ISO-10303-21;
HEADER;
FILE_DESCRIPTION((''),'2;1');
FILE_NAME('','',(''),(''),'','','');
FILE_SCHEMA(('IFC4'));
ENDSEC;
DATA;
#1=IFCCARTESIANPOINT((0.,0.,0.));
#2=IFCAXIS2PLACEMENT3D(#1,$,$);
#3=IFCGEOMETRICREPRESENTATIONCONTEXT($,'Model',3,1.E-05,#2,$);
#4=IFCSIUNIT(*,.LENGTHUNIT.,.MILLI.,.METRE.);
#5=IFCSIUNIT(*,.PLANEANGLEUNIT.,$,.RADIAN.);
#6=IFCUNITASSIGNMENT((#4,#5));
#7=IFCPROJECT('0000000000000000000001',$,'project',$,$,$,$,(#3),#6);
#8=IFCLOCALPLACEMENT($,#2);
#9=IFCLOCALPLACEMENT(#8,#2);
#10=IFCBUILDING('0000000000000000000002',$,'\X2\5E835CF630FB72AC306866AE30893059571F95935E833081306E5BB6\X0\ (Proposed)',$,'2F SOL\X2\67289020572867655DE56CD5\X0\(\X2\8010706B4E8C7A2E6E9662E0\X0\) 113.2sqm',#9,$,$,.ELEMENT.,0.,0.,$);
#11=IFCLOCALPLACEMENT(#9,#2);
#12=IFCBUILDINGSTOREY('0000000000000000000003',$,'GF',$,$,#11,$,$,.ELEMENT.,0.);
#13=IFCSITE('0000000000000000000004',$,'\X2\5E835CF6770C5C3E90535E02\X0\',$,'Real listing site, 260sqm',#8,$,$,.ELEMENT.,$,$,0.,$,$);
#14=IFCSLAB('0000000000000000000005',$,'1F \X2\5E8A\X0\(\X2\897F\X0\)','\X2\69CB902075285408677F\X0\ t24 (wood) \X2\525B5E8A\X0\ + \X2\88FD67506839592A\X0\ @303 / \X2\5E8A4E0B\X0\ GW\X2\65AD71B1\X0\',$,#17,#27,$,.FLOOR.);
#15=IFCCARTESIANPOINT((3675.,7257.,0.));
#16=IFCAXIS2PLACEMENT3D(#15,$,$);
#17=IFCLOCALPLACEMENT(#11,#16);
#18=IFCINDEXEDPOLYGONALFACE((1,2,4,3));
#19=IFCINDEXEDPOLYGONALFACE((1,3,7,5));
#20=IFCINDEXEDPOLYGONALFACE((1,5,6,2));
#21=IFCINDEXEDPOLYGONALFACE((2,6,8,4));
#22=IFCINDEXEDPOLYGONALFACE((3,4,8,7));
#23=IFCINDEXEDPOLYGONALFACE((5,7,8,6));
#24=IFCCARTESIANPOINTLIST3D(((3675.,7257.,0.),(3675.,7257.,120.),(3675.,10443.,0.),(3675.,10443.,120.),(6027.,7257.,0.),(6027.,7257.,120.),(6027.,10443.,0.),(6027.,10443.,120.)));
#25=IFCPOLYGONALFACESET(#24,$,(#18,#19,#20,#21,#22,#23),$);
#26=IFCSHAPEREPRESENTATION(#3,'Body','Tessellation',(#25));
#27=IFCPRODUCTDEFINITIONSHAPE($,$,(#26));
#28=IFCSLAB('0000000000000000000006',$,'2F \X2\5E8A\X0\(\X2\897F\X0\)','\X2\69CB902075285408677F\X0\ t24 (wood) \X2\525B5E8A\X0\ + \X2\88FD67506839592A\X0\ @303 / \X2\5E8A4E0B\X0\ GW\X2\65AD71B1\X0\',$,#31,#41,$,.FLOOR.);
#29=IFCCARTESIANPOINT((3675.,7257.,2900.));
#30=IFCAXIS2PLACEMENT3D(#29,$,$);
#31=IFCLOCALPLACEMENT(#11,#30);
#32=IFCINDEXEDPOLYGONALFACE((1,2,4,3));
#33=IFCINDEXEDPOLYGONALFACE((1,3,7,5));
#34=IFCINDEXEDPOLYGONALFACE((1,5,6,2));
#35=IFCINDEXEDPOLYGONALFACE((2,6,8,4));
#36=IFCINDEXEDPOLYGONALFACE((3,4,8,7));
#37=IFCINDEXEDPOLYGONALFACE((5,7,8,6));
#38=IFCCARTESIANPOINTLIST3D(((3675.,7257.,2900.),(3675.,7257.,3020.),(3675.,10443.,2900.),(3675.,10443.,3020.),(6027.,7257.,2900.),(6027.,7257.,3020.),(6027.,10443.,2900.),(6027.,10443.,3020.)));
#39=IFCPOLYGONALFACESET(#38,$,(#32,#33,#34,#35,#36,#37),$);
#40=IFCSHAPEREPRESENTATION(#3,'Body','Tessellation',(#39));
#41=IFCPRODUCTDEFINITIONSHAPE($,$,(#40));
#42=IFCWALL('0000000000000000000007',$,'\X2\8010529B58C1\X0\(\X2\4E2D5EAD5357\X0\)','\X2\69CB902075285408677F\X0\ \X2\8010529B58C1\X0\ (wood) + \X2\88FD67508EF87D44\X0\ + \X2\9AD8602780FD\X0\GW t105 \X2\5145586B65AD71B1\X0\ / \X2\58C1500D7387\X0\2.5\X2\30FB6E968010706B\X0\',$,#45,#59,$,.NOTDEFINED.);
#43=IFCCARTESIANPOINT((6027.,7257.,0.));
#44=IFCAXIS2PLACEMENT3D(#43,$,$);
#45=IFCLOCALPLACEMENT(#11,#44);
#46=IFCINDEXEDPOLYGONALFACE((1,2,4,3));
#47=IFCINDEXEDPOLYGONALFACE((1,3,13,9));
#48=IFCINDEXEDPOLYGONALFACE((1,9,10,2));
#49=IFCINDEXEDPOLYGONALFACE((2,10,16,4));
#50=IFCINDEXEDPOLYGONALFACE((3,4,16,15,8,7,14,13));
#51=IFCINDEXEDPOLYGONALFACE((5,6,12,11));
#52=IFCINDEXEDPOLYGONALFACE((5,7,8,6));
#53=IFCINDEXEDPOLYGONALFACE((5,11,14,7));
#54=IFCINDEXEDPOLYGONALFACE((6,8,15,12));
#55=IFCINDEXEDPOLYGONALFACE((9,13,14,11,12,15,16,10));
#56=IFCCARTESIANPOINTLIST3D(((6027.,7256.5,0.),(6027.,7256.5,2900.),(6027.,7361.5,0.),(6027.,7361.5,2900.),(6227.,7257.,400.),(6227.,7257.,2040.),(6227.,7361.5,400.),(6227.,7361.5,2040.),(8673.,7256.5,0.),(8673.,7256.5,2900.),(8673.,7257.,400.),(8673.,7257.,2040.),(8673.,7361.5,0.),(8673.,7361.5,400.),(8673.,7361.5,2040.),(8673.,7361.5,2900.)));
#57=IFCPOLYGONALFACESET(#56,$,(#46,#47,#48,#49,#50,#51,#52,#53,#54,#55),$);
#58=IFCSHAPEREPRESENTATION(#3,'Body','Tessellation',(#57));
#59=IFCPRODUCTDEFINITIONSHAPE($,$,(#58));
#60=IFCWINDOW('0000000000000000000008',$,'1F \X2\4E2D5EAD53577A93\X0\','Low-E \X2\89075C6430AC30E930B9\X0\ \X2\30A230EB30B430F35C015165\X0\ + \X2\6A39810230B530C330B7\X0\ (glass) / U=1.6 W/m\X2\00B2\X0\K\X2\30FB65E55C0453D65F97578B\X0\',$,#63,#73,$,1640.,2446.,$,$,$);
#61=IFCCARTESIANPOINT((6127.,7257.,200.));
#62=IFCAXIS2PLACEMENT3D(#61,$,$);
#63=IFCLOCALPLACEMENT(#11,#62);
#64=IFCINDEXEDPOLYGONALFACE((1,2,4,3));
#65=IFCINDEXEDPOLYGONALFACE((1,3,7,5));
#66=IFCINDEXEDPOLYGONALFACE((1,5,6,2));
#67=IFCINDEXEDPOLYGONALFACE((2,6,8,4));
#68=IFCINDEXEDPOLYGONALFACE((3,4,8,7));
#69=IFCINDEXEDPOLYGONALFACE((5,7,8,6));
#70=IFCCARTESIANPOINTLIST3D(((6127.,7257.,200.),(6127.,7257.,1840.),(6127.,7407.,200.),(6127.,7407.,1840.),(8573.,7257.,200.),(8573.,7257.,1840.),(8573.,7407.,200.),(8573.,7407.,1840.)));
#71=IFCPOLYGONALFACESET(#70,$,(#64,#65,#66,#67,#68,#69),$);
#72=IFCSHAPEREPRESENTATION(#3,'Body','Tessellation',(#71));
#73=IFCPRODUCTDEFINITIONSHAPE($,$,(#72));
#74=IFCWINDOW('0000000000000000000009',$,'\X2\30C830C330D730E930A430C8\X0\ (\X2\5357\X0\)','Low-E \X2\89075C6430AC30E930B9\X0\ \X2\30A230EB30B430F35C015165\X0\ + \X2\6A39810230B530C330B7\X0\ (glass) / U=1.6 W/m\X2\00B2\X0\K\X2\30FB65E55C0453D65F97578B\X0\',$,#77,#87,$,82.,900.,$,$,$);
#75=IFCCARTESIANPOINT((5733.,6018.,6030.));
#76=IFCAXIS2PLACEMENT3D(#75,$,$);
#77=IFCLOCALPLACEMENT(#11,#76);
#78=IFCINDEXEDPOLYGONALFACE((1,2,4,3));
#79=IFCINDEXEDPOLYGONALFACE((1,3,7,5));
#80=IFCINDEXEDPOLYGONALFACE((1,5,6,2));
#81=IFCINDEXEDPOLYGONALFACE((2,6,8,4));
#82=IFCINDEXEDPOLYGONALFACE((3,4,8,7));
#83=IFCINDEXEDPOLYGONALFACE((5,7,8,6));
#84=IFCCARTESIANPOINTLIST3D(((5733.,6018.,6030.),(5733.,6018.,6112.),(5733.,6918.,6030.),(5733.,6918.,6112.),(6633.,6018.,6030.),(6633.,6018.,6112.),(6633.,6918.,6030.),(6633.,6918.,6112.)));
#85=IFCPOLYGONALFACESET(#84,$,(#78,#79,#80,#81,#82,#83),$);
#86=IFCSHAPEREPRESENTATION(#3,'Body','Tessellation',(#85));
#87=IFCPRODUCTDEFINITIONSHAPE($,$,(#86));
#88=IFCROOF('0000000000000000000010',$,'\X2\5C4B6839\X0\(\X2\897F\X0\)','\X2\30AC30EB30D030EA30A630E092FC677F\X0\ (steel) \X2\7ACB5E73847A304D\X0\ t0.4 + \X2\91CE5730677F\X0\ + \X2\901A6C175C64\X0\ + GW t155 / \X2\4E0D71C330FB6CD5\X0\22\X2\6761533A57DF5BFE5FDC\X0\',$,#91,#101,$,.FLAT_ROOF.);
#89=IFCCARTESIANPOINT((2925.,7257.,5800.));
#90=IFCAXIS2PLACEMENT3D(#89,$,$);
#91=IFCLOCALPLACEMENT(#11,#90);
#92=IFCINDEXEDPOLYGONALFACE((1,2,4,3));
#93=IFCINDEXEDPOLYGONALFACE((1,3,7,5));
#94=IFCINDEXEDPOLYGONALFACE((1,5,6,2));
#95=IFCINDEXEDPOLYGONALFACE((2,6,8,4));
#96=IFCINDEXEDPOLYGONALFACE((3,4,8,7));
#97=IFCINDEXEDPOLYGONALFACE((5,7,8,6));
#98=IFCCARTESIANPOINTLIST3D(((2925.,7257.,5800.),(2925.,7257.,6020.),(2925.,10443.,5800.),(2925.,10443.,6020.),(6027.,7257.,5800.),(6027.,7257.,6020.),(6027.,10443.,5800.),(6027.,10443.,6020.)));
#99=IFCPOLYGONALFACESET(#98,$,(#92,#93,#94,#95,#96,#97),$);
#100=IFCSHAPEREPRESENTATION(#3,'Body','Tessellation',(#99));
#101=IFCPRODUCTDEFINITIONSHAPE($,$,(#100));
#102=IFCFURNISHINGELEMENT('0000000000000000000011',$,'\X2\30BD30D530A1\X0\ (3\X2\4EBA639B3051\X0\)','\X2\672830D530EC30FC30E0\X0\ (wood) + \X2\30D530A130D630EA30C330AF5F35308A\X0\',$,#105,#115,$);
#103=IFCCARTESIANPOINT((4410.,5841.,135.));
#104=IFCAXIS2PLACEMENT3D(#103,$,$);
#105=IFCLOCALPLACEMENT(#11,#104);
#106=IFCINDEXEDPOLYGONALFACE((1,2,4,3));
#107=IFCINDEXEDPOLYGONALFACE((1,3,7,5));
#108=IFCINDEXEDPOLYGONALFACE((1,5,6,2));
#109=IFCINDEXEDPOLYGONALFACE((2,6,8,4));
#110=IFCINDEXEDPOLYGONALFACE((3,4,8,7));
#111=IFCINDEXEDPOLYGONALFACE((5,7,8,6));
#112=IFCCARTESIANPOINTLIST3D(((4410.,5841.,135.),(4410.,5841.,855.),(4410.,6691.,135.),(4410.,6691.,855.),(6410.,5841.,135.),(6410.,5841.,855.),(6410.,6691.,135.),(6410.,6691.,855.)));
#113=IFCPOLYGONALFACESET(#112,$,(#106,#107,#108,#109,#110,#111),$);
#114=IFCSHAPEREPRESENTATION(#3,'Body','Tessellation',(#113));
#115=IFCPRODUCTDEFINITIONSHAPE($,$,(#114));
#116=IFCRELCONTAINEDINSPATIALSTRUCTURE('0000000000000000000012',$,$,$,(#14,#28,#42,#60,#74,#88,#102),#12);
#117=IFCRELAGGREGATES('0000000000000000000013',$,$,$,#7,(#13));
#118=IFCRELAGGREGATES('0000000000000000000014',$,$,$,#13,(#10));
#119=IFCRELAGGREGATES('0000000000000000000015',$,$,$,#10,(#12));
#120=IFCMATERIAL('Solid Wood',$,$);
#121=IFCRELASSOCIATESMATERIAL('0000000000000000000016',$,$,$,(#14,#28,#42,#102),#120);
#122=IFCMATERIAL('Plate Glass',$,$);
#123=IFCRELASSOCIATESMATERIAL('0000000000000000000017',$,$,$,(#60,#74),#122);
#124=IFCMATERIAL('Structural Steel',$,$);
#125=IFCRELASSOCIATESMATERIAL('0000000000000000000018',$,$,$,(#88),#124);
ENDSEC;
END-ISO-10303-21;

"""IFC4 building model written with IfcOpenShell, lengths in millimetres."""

from ifc_helpers import new_model, si_unit, frame, frame_2d, origin, place, context, project, spatial, rectangle, extrude, material, element, fill, save


model = new_model("IFC4")

# Units and contexts
model_context = context("Model", 3, precision=1e-05, world=origin())
ifc_project = project(units=[si_unit("LENGTHUNIT", "METRE", prefix="MILLI"), si_unit("PLANEANGLEUNIT", "RADIAN")], contexts=[model_context])

# Site, building, storey
site_placement = place(None, origin())
site = spatial("IfcSite", under=ifc_project, at=site_placement, Name="広島県尾道市", ObjectType="Real listing site, 260sqm", CompositionType="ELEMENT", RefElevation=0.0)
building_placement = place(site_placement, origin())
building = spatial("IfcBuilding", under=site, at=building_placement, Name="広島・犬と暮らす土間広めの家 (Proposed)", ObjectType="2F SOL木造在来工法(耐火二種準拠) 113.2sqm", CompositionType="ELEMENT", ElevationOfRefHeight=0.0, ElevationOfTerrain=0.0)
storey_placement = place(building_placement, origin())
storey = spatial("IfcBuildingStorey", under=building, at=storey_placement, Name="GF", CompositionType="ELEMENT", Elevation=0.0)

# Shared definitions
ifc_material_1 = material(Name="Solid Wood")

# Slabs
slab_1_placement = place(storey_placement, frame((3675.0, 7257.0, 0.0)))
element("IfcSlab", 1, at=slab_1_placement, inside=storey, material=ifc_material_1, Name="1F 床(西)", Description="構造用合板 t24 (wood) 剛床 + 製材根太 @303 / 床下 GW断熱", PredefinedType="FLOOR", context=model_context, shape_type="SweptSolid", body=[
    extrude(rectangle(XDim=2352.0, YDim=3186.0, at=frame_2d((1176.0, 1593.0))), frame((3675.0, 7257.0, 0.0)), (0.0, 0.0, 1.0), 120.0),
])
slab_2_placement = place(storey_placement, frame((3675.0, 7257.0, 2900.0)))
element("IfcSlab", 2, at=slab_2_placement, inside=storey, material=ifc_material_1, Name="2F 床(西)", Description="構造用合板 t24 (wood) 剛床 + 製材根太 @303 / 床下 GW断熱", PredefinedType="FLOOR", context=model_context, shape_type="SweptSolid", body=[
    extrude(rectangle(XDim=2352.0, YDim=3186.0, at=frame_2d((1176.0, 1593.0))), frame((3675.0, 7257.0, 2900.0)), (0.0, 0.0, 1.0), 120.0),
])

# Wall, opening, window
wall_1_placement = place(storey_placement, frame((6027.0, 7257.0, 0.0)))
wall_1 = element("IfcWall", 3, at=wall_1_placement, inside=storey, material=ifc_material_1, Name="耐力壁(中庭南)", Description="構造用合板 耐力壁 (wood) + 製材軸組 + 高性能GW t105 充填断熱 / 壁倍率2.5・準耐火", PredefinedType="NOTDEFINED", context=model_context, shape_type="SweptSolid", body=[
    extrude(rectangle(XDim=2646.0, YDim=105.0, at=frame_2d((1323.0, 52.0))), frame((6027.0, 7257.0, 0.0)), (0.0, 0.0, 1.0), 2900.0),
])
opening_placement = place(storey_placement, frame((6127.0, 7257.0, 200.0)))
opening = element("IfcOpeningElement", 4, at=opening_placement, cuts=wall_1, PredefinedType="NOTDEFINED", context=model_context, shape_type="SweptSolid", body=[
    extrude(rectangle(XDim=2446.0, YDim=150.0, at=frame_2d((1223.0, 75.0))), frame((6127.0, 7257.0, 200.0)), (0.0, 0.0, 1.0), 1640.0),
])
ifc_material_2 = material(Name="Plate Glass")
window_1_placement = place(storey_placement, frame((6127.0, 7257.0, 200.0)))
window_1 = element("IfcWindow", 5, at=window_1_placement, inside=storey, material=ifc_material_2, Name="1F 中庭南窓", Description="Low-E 複層ガラス アルゴン封入 + 樹脂サッシ (glass) / U=1.6 W/m²K・日射取得型", OverallHeight=1640.0, OverallWidth=2446.0, context=model_context, shape_type="SweptSolid", body=[
    extrude(rectangle(XDim=2446.0, YDim=150.0, at=frame_2d((1223.0, 75.0))), frame((6127.0, 7257.0, 200.0)), (0.0, 0.0, 1.0), 1640.0),
])
fill(opening, window_1)

# Window
window_2_placement = place(storey_placement, frame((5733.0, 6018.0, 6030.0)))
element("IfcWindow", 6, at=window_2_placement, inside=storey, material=ifc_material_2, Name="トップライト (南)", Description="Low-E 複層ガラス アルゴン封入 + 樹脂サッシ (glass) / U=1.6 W/m²K・日射取得型", OverallHeight=82.0, OverallWidth=900.0, context=model_context, shape_type="SweptSolid", body=[
    extrude(rectangle(XDim=900.0, YDim=900.0, at=frame_2d((450.0, 450.0))), frame((5733.0, 6018.0, 6030.0)), (0.0, 0.0, 1.0), 82.0),
])

# Roof
ifc_material_3 = material(Name="Structural Steel")
for number, where, name in (
    (7, (2925.0, 7257.0, 5800.0), "屋根(西)"),
):
    element("IfcRoof", number, at=place(storey_placement, frame(where)), inside=storey, material=ifc_material_3, Name=name, Description="ガルバリウム鋼板 (steel) 立平葺き t0.4 + 野地板 + 通気層 + GW t155 / 不燃・法22条区域対応", PredefinedType="FLAT_ROOF", context=model_context, shape_type="SweptSolid", body=[
        extrude(rectangle(XDim=3102.0, YDim=3186.0, at=frame_2d((1551.0, 1593.0))), frame((2925.0, 7257.0, 5800.0)), (0.0, 0.0, 1.0), 220.0),
    ])

# Furnishing element
furnishing_placement = place(storey_placement, frame((4410.0, 5841.0, 135.0)))
element("IfcFurnishingElement", 8, at=furnishing_placement, inside=storey, material=ifc_material_1, Name="ソファ (3人掛け)", Description="木フレーム (wood) + ファブリック張り", context=model_context, shape_type="SweptSolid", body=[
    extrude(rectangle(XDim=2000.0, YDim=850.0, at=frame_2d((1000.0, 425.0))), frame((4410.0, 5841.0, 135.0)), (0.0, 0.0, 1.0), 720.0),
])

save(model, "model.ifc")
